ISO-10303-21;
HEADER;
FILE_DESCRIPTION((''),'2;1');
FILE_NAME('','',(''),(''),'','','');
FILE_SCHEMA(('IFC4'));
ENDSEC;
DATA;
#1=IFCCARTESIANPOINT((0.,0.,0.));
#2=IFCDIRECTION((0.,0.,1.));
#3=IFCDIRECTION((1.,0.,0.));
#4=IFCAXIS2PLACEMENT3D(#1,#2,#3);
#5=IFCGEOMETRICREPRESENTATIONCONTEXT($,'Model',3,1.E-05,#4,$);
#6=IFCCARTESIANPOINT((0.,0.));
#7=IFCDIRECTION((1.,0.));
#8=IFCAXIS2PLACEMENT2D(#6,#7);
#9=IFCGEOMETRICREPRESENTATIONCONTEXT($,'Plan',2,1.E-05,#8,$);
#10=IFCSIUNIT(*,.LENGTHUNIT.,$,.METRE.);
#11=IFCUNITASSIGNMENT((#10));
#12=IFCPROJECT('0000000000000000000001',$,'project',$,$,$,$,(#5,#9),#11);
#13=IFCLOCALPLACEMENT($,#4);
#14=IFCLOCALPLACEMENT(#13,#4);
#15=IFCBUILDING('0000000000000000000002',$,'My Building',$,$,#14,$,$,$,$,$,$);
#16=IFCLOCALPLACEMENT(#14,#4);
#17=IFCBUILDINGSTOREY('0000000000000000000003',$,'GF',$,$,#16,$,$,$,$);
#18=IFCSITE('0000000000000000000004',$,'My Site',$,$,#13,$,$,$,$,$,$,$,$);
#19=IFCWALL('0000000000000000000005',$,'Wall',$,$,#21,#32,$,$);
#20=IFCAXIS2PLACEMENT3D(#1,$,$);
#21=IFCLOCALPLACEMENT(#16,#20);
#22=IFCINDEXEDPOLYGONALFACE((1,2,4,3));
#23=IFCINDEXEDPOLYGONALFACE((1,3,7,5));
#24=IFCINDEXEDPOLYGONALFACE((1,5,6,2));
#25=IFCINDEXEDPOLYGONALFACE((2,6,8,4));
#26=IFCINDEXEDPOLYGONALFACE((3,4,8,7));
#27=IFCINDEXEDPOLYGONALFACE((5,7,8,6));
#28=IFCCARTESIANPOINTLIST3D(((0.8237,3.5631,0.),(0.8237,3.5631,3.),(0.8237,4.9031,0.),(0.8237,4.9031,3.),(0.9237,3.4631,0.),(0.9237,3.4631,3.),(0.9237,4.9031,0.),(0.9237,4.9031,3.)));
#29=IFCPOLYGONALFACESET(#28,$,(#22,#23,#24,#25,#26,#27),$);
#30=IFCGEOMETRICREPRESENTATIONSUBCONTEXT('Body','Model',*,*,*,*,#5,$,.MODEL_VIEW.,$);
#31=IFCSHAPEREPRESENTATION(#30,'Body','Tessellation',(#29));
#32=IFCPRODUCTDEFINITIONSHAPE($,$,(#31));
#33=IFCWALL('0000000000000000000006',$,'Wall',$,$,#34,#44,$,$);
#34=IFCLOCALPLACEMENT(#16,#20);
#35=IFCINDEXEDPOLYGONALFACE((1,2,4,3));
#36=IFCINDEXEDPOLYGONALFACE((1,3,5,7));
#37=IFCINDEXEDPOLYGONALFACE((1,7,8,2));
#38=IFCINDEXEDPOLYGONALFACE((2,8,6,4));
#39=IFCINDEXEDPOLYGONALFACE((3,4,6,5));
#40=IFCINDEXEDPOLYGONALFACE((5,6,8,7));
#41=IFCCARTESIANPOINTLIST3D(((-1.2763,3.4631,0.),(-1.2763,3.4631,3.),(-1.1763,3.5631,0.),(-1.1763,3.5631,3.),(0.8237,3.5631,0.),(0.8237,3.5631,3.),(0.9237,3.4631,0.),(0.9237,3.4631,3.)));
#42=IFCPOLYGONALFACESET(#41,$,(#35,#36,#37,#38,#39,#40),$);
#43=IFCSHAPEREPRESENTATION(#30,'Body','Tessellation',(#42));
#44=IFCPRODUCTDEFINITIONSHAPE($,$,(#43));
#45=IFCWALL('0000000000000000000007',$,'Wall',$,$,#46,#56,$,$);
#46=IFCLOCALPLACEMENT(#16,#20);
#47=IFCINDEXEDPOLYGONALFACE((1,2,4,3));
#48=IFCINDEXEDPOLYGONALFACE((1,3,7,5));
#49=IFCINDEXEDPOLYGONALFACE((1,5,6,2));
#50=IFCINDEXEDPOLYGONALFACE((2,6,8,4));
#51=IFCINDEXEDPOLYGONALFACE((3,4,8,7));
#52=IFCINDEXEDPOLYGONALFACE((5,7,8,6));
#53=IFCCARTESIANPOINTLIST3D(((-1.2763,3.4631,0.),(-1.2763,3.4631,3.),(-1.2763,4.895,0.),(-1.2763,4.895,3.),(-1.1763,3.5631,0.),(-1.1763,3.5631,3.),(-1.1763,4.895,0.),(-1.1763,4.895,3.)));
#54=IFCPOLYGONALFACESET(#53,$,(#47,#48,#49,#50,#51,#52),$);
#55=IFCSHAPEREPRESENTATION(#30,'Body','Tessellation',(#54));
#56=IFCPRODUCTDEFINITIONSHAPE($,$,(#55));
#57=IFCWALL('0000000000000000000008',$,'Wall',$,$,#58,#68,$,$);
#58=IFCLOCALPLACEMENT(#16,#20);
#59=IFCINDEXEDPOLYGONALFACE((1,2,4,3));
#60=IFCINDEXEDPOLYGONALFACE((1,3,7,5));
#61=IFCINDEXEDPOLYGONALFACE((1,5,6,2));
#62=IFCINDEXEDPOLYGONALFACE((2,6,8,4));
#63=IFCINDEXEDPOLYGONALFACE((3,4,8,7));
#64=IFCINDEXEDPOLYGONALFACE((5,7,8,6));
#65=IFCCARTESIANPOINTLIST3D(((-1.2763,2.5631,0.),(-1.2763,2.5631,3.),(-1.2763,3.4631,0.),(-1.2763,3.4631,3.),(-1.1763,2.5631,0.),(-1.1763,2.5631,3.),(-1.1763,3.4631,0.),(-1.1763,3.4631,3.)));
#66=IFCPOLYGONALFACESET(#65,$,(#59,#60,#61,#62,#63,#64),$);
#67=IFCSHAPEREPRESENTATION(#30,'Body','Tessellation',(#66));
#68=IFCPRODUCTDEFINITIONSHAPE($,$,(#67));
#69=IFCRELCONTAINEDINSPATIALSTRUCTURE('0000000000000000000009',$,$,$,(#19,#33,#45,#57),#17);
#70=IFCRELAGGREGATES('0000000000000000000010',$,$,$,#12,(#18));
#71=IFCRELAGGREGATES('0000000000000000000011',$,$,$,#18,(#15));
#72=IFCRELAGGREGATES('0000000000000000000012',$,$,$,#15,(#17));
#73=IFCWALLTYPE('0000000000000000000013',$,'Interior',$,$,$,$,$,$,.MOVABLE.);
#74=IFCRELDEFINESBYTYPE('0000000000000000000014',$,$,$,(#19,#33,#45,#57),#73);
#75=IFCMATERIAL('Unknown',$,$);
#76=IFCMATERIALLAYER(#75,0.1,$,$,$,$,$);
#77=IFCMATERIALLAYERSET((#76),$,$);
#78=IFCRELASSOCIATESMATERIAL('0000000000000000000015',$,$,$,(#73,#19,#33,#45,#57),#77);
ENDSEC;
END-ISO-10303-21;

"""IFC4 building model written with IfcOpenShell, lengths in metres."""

from ifc_helpers import new_model, si_unit, frame, origin_with_axes, origin_2d_with_axis, place, context, subcontext, project, spatial, line, indexed_curve, outline, extrude, material, layer, layer_set, layer_usage, type_object, element, save


model = new_model("IFC4")

# Units and contexts
model_context = context("Model", 3, precision=1e-05, world=origin_with_axes())
plan_context = context("Plan", 2, precision=1e-05, world=origin_2d_with_axis())
body_context_1 = subcontext(model_context, "Body", "Model", "MODEL_VIEW")
ifc_project = project(units=[si_unit("LENGTHUNIT", "METRE")], contexts=[model_context, plan_context])

# Site, building, storey
site_placement = place(None, origin_with_axes())
site = spatial("IfcSite", under=ifc_project, at=site_placement, Name="My Site")
building_placement = place(site_placement, origin_with_axes())
building = spatial("IfcBuilding", under=site, at=building_placement, Name="My Building")
storey_placement = place(building_placement, origin_with_axes())
storey = spatial("IfcBuildingStorey", under=building, at=storey_placement, Name="GF")

# Shared definitions
ifc_material = material(Name="Unknown")

# Walls
ifc_layer_1 = layer(ifc_material, 0.1)
ifc_layer_set_1 = layer_set([ifc_layer_1])
ifc_layer_usage_1 = layer_usage(ifc_layer_set_1, "AXIS2", "POSITIVE", 0.0)
wall_type_1 = type_object("IfcWallType", Name="Interior", PredefinedType="MOVABLE", material=ifc_layer_set_1)
wall_1_placement = place(storey_placement, frame((0.8237, 4.9031, 0.0), z_axis=(0.0, 0.0, 1.0), x_axis=(0.0, -1.0, 0.0)))
element("IfcWall", 1, at=wall_1_placement, inside=storey, type_object=wall_type_1, material=ifc_layer_usage_1, Name="Wall", context=body_context_1, shape_type="SweptSolid", body=[
    extrude(outline(indexed_curve([(0.0, 0.0), (0.0, 0.1), (1.44, 0.1), (1.34, 0.0)], segments=[line(1, 2, 3, 4, 1)])), origin_with_axes(), (0.0, 0.0, 1.0), 3.0),
])
ifc_layer_usage_2 = layer_usage(ifc_layer_set_1, "AXIS2", "POSITIVE", 0.0)
wall_2_placement = place(storey_placement, frame((0.8237, 3.5631, 0.0), z_axis=(0.0, 0.0, 1.0), x_axis=(-1.0, 0.0, 0.0)))
element("IfcWall", 2, at=wall_2_placement, inside=storey, type_object=wall_type_1, material=ifc_layer_usage_2, Name="Wall", context=body_context_1, shape_type="SweptSolid", body=[
    extrude(outline(indexed_curve([(0.0, 0.0), (-0.1, 0.1), (2.1, 0.1), (2.0, 0.0)], segments=[line(1, 2, 3, 4, 1)])), origin_with_axes(), (0.0, 0.0, 1.0), 3.0),
])
ifc_layer_usage_3 = layer_usage(ifc_layer_set_1, "AXIS2", "POSITIVE", 0.0)
wall_3_placement = place(storey_placement, frame((-1.1763, 3.5631, 0.0), z_axis=(0.0, 0.0, 1.0), x_axis=(0.0, 1.0, 0.0)))
element("IfcWall", 3, at=wall_3_placement, inside=storey, type_object=wall_type_1, material=ifc_layer_usage_3, Name="Wall", context=body_context_1, shape_type="SweptSolid", body=[
    extrude(outline(indexed_curve([(0.0, 0.0), (-0.1, 0.1), (1.3318, 0.1), (1.3318, 0.0)], segments=[line(1, 2, 3, 4, 1)])), origin_with_axes(), (0.0, 0.0, 1.0), 3.0),
])
ifc_layer_usage_4 = layer_usage(ifc_layer_set_1, "AXIS2", "POSITIVE", 0.0)
wall_4_placement = place(storey_placement, frame((-1.2763, 3.4631, 0.0), z_axis=(0.0, 0.0, 1.0), x_axis=(0.0, -1.0, 0.0)))
element("IfcWall", 4, at=wall_4_placement, inside=storey, type_object=wall_type_1, material=ifc_layer_usage_4, Name="Wall", context=body_context_1, shape_type="SweptSolid", body=[
    extrude(outline(indexed_curve([(0.0, 0.0), (0.0, 0.1), (0.9, 0.1), (0.9, 0.0)], segments=[line(1, 2, 3, 4, 1)])), origin_with_axes(), (0.0, 0.0, 1.0), 3.0),
])

save(model, "model.ifc")
